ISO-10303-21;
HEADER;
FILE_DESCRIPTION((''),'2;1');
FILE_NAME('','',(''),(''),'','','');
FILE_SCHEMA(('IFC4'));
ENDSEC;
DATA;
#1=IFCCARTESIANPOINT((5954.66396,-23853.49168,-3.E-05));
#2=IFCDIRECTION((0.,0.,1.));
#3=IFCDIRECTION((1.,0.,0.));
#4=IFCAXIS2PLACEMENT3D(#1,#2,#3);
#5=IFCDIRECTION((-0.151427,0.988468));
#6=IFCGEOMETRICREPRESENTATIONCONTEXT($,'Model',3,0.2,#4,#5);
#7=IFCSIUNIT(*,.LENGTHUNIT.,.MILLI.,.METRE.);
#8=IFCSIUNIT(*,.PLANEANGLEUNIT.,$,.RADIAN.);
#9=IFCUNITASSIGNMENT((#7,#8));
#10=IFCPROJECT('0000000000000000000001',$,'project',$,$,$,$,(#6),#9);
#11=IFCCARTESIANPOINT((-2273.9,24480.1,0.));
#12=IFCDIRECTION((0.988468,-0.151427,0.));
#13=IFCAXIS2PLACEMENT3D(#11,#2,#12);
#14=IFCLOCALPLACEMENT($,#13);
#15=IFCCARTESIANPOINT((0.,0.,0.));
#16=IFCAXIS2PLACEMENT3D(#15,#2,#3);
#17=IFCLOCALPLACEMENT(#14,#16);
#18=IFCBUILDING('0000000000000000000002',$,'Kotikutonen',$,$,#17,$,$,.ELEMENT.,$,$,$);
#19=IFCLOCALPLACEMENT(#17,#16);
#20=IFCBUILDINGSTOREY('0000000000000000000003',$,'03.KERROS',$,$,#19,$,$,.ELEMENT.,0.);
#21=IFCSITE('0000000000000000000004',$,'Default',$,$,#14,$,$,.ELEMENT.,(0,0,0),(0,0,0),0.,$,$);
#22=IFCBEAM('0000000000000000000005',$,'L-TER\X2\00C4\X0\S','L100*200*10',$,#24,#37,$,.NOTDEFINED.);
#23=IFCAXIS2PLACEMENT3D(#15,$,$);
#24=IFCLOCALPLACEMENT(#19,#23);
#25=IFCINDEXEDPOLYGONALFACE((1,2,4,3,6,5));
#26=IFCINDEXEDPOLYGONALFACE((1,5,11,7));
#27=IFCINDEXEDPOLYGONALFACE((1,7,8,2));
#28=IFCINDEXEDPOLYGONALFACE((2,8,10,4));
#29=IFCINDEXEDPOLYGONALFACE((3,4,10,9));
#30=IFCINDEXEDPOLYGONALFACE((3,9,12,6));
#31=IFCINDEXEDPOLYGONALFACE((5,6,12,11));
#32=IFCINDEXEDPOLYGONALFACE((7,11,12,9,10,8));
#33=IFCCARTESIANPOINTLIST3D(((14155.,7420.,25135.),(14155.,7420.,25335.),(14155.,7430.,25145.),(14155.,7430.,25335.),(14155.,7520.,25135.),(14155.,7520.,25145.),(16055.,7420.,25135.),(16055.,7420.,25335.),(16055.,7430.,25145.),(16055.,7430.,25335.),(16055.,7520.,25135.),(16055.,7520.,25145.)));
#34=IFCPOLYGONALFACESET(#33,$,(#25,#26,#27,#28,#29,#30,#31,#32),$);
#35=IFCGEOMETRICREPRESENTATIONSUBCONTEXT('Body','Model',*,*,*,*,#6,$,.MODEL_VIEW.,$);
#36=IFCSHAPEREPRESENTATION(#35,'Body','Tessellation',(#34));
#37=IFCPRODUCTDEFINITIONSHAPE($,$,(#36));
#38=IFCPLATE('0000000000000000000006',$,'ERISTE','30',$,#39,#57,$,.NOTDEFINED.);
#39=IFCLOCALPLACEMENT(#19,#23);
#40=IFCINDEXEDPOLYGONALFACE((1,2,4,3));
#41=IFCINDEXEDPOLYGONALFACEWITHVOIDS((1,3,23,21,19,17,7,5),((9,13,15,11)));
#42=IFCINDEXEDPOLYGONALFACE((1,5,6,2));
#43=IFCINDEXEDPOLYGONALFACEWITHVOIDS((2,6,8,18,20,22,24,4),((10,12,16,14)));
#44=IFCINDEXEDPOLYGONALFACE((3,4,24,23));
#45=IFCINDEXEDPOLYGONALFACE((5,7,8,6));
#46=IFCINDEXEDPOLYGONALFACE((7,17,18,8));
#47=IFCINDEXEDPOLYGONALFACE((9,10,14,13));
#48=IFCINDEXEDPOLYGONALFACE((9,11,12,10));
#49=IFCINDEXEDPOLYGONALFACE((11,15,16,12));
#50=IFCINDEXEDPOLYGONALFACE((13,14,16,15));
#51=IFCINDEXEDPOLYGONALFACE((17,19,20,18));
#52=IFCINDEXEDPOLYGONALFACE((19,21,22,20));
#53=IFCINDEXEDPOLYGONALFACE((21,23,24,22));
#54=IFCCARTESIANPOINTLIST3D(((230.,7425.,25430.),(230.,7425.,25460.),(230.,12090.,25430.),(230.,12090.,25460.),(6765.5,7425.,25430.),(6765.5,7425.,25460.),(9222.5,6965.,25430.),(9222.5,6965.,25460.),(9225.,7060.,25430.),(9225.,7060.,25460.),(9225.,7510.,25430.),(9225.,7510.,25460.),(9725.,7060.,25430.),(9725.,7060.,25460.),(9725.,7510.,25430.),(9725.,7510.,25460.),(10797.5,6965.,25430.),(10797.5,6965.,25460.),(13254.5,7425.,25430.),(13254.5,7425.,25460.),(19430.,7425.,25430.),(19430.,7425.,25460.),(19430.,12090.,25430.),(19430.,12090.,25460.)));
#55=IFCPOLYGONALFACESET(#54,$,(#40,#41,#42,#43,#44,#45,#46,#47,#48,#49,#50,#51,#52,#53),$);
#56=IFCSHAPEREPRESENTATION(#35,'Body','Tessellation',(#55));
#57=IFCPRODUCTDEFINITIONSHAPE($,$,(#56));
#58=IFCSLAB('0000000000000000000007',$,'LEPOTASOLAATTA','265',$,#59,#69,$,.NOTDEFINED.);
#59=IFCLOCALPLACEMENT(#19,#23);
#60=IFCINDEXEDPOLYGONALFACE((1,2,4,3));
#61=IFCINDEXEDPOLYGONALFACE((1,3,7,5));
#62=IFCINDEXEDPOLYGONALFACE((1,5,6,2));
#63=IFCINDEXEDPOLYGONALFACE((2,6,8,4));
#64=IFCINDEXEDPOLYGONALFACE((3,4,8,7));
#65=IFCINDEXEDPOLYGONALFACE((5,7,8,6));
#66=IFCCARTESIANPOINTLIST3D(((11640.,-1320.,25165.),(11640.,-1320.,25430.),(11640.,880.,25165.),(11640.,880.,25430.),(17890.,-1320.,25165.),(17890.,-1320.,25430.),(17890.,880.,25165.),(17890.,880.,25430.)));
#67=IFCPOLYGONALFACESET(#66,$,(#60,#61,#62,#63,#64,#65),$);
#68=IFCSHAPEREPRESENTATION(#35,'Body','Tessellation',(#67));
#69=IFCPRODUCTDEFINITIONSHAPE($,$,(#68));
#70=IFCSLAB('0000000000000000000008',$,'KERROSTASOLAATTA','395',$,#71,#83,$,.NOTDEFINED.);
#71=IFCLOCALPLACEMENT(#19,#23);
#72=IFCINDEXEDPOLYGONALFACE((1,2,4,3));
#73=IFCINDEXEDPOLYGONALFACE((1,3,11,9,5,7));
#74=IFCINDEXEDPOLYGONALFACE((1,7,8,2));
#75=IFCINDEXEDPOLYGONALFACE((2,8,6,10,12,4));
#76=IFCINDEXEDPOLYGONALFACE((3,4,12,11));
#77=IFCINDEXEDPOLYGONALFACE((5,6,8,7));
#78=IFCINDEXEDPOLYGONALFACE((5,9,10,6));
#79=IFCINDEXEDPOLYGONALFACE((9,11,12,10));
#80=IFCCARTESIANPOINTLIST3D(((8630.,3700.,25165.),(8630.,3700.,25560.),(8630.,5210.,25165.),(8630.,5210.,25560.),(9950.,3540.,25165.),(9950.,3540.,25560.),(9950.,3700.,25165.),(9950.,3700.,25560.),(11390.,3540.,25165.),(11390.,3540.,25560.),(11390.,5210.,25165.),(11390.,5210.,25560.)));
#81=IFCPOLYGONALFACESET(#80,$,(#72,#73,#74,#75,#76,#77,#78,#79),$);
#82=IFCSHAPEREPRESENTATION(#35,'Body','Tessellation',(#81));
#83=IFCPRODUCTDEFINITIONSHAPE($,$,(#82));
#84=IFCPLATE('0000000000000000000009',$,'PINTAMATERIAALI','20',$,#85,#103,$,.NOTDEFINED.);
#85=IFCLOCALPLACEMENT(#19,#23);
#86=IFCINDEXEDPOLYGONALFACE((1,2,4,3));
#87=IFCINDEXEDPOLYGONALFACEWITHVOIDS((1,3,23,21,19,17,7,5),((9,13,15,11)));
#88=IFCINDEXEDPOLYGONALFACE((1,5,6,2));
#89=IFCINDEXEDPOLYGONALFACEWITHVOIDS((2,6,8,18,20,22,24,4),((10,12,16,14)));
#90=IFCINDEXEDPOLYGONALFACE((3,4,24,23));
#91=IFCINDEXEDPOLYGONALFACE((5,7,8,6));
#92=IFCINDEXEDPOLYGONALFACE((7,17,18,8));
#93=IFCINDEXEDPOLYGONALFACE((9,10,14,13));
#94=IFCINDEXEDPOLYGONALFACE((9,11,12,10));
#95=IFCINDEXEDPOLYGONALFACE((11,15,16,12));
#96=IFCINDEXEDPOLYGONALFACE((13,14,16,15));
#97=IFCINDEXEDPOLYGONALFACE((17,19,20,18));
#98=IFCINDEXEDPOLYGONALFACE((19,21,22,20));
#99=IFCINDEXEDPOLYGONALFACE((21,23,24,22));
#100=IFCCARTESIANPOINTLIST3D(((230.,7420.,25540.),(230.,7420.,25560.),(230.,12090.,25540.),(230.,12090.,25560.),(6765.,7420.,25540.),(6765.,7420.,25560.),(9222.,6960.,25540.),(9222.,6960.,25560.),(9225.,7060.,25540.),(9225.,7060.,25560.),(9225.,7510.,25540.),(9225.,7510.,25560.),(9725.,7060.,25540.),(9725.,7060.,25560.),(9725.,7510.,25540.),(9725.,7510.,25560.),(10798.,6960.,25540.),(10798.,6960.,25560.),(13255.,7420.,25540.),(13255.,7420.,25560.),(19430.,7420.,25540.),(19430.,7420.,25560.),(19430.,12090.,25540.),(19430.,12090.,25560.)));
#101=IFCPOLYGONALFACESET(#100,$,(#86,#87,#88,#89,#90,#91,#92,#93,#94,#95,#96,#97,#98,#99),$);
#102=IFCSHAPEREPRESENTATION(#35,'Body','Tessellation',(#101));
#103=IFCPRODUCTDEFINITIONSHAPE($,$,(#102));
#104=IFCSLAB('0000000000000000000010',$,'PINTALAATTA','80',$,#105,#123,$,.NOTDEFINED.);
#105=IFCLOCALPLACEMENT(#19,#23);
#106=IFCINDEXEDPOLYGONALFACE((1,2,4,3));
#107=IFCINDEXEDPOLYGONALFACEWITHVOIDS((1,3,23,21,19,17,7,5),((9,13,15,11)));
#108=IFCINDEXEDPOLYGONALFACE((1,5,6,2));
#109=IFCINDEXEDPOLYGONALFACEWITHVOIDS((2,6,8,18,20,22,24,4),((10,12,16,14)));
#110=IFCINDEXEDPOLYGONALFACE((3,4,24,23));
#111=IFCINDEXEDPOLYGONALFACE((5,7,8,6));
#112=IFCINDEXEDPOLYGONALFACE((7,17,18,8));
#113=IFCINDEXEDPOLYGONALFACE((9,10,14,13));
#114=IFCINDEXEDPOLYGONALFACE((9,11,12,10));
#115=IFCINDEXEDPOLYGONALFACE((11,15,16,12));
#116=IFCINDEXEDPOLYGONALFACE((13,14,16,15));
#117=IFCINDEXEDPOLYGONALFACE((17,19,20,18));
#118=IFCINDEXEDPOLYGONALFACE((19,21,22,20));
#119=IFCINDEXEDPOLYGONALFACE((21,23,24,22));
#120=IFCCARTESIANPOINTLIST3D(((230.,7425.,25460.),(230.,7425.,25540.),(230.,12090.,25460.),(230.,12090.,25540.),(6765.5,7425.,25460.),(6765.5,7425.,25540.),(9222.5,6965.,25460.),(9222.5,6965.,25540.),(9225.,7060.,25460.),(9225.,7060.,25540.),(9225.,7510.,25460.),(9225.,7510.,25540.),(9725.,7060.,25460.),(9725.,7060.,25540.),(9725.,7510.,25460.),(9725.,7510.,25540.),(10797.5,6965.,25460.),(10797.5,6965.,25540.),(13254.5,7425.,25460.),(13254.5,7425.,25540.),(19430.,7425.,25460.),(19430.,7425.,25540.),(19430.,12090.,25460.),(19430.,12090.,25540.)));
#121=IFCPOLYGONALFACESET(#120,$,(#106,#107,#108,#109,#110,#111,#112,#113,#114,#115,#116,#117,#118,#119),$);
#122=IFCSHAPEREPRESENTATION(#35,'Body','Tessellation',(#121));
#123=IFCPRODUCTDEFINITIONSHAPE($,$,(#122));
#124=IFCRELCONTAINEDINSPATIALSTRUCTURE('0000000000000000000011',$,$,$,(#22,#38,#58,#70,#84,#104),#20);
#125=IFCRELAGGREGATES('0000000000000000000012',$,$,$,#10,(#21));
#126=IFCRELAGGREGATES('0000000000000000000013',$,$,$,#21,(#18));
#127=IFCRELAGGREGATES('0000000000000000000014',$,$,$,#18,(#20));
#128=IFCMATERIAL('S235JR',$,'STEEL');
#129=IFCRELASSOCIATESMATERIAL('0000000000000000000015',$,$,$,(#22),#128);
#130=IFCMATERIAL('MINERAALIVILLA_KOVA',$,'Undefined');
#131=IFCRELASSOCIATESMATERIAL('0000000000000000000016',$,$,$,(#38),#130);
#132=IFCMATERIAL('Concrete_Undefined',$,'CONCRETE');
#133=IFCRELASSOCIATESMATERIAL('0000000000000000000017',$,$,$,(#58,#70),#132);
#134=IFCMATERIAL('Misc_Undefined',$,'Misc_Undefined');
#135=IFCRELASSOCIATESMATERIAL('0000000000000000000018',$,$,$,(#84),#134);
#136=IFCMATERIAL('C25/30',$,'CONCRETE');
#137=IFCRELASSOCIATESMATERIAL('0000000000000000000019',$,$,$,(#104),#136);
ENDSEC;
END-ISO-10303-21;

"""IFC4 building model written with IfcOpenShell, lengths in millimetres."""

from ifc_helpers import new_model, si_unit, direction, frame, origin_with_axes, place, context, subcontext, project, spatial, line, indexed_curve, outline, extrude, material, element, save


model = new_model("IFC4")

# Units and contexts
model_context = context("Model", 3, precision=0.2, world=frame((5954.66396, -23853.49168, -3e-05), z_axis=(0.0, 0.0, 1.0), x_axis=(1.0, 0.0, 0.0)), true_north=direction((-0.151427, 0.988468)))
body_context = subcontext(model_context, "Body", "Model", "MODEL_VIEW")
ifc_project = project(units=[si_unit("LENGTHUNIT", "METRE", prefix="MILLI"), si_unit("PLANEANGLEUNIT", "RADIAN")], contexts=[model_context])

# Site, building, storey
site_placement = place(None, frame((-2273.9, 24480.1, 0.0), z_axis=(0.0, 0.0, 1.0), x_axis=(0.988468, -0.151427, 0.0)))
site = spatial("IfcSite", under=ifc_project, at=site_placement, Name="Default", CompositionType="ELEMENT", RefLatitude=(0, 0, 0), RefLongitude=(0, 0, 0), RefElevation=0.0)
building_placement = place(site_placement, origin_with_axes())
building = spatial("IfcBuilding", under=site, at=building_placement, Name="Kotikutonen", CompositionType="ELEMENT")
storey_placement = place(building_placement, origin_with_axes())
storey = spatial("IfcBuildingStorey", under=building, at=storey_placement, Name="03.KERROS", CompositionType="ELEMENT", Elevation=0.0)

# Shared definitions
ifc_material_1 = material(Name="Concrete_Undefined", Category="CONCRETE")

# Beam
ifc_material_2 = material(Name="S235JR", Category="STEEL")
for number, where, z_axis, x_axis, name in (
    (1, (14155.0, 7470.0, 25235.0), (0.0, 0.0, 1.0), (1.0, 0.0, 0.0), "L-TERÄS"),
):
    element("IfcBeam", number, at=place(storey_placement, frame(where, z_axis=z_axis, x_axis=x_axis)), inside=storey, material=ifc_material_2, Name=name, Description="L100*200*10", PredefinedType="NOTDEFINED", context=body_context, shape_type="SolidModel", body=[
        extrude(outline(indexed_curve([(-100.0, -50.0), (100.0, -50.0), (100.0, -40.0), (-90.0, -40.0), (-90.0, 50.0), (-100.0, 50.0)], segments=[line(1, 2, 3, 4, 5, 6, 1)])), frame((0.0, 0.0, 0.0), z_axis=(-1.0, 0.0, 0.0), x_axis=(0.0, 0.0, 1.0)), (0.0, 0.0, -1.0), 1900.0),
    ])

# Plate, voiding feature
ifc_material_3 = material(Name="MINERAALIVILLA_KOVA", Category="Undefined")
plate_1_placement = place(storey_placement, frame((19430.0, 12090.0, 25445.0), z_axis=(0.0, 0.0, 1.0), x_axis=(-1.0, 0.0, 0.0)))
plate_1 = element("IfcPlate", 2, at=plate_1_placement, inside=storey, material=ifc_material_3, Name="ERISTE", Description="30", PredefinedType="NOTDEFINED", context=body_context, shape_type="SolidModel", body=[
    extrude(outline(indexed_curve([(0.0, 0.0), (19200.0, 0.0), (19200.0, 4665.0), (12664.5, 4665.0), (10207.5, 5125.0), (8632.5, 5125.0), (6175.5, 4665.0), (0.0, 4665.0)], segments=[line(1, 2, 3, 4, 5, 6, 7, 8, 1)])), frame((0.0, 0.0, 15.0), z_axis=(0.0, 0.0, 1.0), x_axis=(1.0, 0.0, 0.0)), (0.0, 0.0, -1.0), 30.0),
])
voiding_feature_1_placement = place(plate_1_placement, frame((10205.0, 4580.0, 0.0), z_axis=(0.0, 0.0, 1.0), x_axis=(0.0, 1.0, 0.0)))
element("IfcVoidingFeature", 3, at=voiding_feature_1_placement, cuts=plate_1, Name="POLYGON CUT", PredefinedType="HOLE", context=body_context, shape_type="SolidModel", body=[
    extrude(outline(indexed_curve([(0.0, 0.0), (450.0, 0.0), (450.0, 500.0), (0.0, 500.0)], segments=[line(1, 2, 3, 4, 1)])), frame((0.0, 0.0, 90.0), z_axis=(0.0, 0.0, 1.0), x_axis=(1.0, 0.0, 0.0)), (0.0, 0.0, -1.0), 180.0),
])

# Slabs
slab_1_placement = place(storey_placement, frame((11640.0, 880.0, 25297.5), z_axis=(0.0, 0.0, 1.0), x_axis=(0.0, -1.0, 0.0)))
element("IfcSlab", 4, at=slab_1_placement, inside=storey, material=ifc_material_1, Name="LEPOTASOLAATTA", Description="265", PredefinedType="NOTDEFINED", context=body_context, shape_type="SolidModel", body=[
    extrude(outline(indexed_curve([(0.0, 0.0), (2200.0, 0.0), (2200.0, 6250.0), (0.0, 6250.0)], segments=[line(1, 2, 3, 4, 1)])), frame((0.0, 0.0, 132.5), z_axis=(0.0, 0.0, 1.0), x_axis=(1.0, 0.0, 0.0)), (0.0, 0.0, -1.0), 265.0),
])
slab_2_placement = place(storey_placement, frame((8630.0, 5210.0, 25362.5), z_axis=(0.0, 0.0, 1.0), x_axis=(0.0, -1.0, 0.0)))
element("IfcSlab", 5, at=slab_2_placement, inside=storey, material=ifc_material_1, Name="KERROSTASOLAATTA", Description="395", PredefinedType="NOTDEFINED", context=body_context, shape_type="SolidModel", body=[
    extrude(outline(indexed_curve([(0.0, 0.0), (1510.0, 0.0), (1510.0, 1320.0), (1670.0, 1320.0), (1670.0, 2760.0), (0.0, 2760.0)], segments=[line(1, 2, 3, 4, 5, 6, 1)])), frame((0.0, 0.0, 197.5), z_axis=(0.0, 0.0, 1.0), x_axis=(1.0, 0.0, 0.0)), (0.0, 0.0, -1.0), 395.0),
])

# Plate, voiding feature
ifc_material_4 = material(Name="Misc_Undefined", Category="Misc_Undefined")
plate_2_placement = place(storey_placement, frame((19430.0, 12090.0, 25550.0), z_axis=(0.0, 0.0, 1.0), x_axis=(-1.0, 0.0, 0.0)))
plate_2 = element("IfcPlate", 6, at=plate_2_placement, inside=storey, material=ifc_material_4, Name="PINTAMATERIAALI", Description="20", PredefinedType="NOTDEFINED", context=body_context, shape_type="SolidModel", body=[
    extrude(outline(indexed_curve([(0.0, 0.0), (19200.0, 0.0), (19200.0, 4670.0), (12665.0, 4670.0), (10208.0, 5130.0), (8632.0, 5130.0), (6175.0, 4670.0), (0.0, 4670.0)], segments=[line(1, 2, 3, 4, 5, 6, 7, 8, 1)])), frame((0.0, 0.0, 10.0), z_axis=(0.0, 0.0, 1.0), x_axis=(1.0, 0.0, 0.0)), (0.0, 0.0, -1.0), 20.0),
])
voiding_feature_2_placement = place(plate_2_placement, frame((10205.0, 4580.0, 0.0), z_axis=(0.0, 0.0, 1.0), x_axis=(0.0, 1.0, 0.0)))
element("IfcVoidingFeature", 7, at=voiding_feature_2_placement, cuts=plate_2, Name="POLYGON CUT", PredefinedType="HOLE", context=body_context, shape_type="SolidModel", body=[
    extrude(outline(indexed_curve([(0.0, 0.0), (450.0, 0.0), (450.0, 500.0), (0.0, 500.0)], segments=[line(1, 2, 3, 4, 1)])), frame((0.0, 0.0, 85.0), z_axis=(0.0, 0.0, 1.0), x_axis=(1.0, 0.0, 0.0)), (0.0, 0.0, -1.0), 170.0),
])

# Slab, voiding feature
ifc_material_5 = material(Name="C25/30", Category="CONCRETE")
slab_3_placement = place(storey_placement, frame((19430.0, 12090.0, 25500.0), z_axis=(0.0, 0.0, 1.0), x_axis=(-1.0, 0.0, 0.0)))
slab_3 = element("IfcSlab", 8, at=slab_3_placement, inside=storey, material=ifc_material_5, Name="PINTALAATTA", Description="80", PredefinedType="NOTDEFINED", context=body_context, shape_type="SolidModel", body=[
    extrude(outline(indexed_curve([(0.0, 0.0), (19200.0, 0.0), (19200.0, 4665.0), (12664.5, 4665.0), (10207.5, 5125.0), (8632.5, 5125.0), (6175.5, 4665.0), (0.0, 4665.0)], segments=[line(1, 2, 3, 4, 5, 6, 7, 8, 1)])), frame((0.0, 0.0, 40.0), z_axis=(0.0, 0.0, 1.0), x_axis=(1.0, 0.0, 0.0)), (0.0, 0.0, -1.0), 80.0),
])
voiding_feature_3_placement = place(slab_3_placement, frame((10205.0, 4580.0, 0.0), z_axis=(0.0, 0.0, 1.0), x_axis=(0.0, 1.0, 0.0)))
element("IfcVoidingFeature", 9, at=voiding_feature_3_placement, cuts=slab_3, Name="POLYGON CUT", PredefinedType="HOLE", context=body_context, shape_type="SolidModel", body=[
    extrude(outline(indexed_curve([(0.0, 0.0), (450.0, 0.0), (450.0, 500.0), (0.0, 500.0)], segments=[line(1, 2, 3, 4, 1)])), frame((0.0, 0.0, 115.0), z_axis=(0.0, 0.0, 1.0), x_axis=(1.0, 0.0, 0.0)), (0.0, 0.0, -1.0), 230.0),
])

save(model, "model.ifc")
